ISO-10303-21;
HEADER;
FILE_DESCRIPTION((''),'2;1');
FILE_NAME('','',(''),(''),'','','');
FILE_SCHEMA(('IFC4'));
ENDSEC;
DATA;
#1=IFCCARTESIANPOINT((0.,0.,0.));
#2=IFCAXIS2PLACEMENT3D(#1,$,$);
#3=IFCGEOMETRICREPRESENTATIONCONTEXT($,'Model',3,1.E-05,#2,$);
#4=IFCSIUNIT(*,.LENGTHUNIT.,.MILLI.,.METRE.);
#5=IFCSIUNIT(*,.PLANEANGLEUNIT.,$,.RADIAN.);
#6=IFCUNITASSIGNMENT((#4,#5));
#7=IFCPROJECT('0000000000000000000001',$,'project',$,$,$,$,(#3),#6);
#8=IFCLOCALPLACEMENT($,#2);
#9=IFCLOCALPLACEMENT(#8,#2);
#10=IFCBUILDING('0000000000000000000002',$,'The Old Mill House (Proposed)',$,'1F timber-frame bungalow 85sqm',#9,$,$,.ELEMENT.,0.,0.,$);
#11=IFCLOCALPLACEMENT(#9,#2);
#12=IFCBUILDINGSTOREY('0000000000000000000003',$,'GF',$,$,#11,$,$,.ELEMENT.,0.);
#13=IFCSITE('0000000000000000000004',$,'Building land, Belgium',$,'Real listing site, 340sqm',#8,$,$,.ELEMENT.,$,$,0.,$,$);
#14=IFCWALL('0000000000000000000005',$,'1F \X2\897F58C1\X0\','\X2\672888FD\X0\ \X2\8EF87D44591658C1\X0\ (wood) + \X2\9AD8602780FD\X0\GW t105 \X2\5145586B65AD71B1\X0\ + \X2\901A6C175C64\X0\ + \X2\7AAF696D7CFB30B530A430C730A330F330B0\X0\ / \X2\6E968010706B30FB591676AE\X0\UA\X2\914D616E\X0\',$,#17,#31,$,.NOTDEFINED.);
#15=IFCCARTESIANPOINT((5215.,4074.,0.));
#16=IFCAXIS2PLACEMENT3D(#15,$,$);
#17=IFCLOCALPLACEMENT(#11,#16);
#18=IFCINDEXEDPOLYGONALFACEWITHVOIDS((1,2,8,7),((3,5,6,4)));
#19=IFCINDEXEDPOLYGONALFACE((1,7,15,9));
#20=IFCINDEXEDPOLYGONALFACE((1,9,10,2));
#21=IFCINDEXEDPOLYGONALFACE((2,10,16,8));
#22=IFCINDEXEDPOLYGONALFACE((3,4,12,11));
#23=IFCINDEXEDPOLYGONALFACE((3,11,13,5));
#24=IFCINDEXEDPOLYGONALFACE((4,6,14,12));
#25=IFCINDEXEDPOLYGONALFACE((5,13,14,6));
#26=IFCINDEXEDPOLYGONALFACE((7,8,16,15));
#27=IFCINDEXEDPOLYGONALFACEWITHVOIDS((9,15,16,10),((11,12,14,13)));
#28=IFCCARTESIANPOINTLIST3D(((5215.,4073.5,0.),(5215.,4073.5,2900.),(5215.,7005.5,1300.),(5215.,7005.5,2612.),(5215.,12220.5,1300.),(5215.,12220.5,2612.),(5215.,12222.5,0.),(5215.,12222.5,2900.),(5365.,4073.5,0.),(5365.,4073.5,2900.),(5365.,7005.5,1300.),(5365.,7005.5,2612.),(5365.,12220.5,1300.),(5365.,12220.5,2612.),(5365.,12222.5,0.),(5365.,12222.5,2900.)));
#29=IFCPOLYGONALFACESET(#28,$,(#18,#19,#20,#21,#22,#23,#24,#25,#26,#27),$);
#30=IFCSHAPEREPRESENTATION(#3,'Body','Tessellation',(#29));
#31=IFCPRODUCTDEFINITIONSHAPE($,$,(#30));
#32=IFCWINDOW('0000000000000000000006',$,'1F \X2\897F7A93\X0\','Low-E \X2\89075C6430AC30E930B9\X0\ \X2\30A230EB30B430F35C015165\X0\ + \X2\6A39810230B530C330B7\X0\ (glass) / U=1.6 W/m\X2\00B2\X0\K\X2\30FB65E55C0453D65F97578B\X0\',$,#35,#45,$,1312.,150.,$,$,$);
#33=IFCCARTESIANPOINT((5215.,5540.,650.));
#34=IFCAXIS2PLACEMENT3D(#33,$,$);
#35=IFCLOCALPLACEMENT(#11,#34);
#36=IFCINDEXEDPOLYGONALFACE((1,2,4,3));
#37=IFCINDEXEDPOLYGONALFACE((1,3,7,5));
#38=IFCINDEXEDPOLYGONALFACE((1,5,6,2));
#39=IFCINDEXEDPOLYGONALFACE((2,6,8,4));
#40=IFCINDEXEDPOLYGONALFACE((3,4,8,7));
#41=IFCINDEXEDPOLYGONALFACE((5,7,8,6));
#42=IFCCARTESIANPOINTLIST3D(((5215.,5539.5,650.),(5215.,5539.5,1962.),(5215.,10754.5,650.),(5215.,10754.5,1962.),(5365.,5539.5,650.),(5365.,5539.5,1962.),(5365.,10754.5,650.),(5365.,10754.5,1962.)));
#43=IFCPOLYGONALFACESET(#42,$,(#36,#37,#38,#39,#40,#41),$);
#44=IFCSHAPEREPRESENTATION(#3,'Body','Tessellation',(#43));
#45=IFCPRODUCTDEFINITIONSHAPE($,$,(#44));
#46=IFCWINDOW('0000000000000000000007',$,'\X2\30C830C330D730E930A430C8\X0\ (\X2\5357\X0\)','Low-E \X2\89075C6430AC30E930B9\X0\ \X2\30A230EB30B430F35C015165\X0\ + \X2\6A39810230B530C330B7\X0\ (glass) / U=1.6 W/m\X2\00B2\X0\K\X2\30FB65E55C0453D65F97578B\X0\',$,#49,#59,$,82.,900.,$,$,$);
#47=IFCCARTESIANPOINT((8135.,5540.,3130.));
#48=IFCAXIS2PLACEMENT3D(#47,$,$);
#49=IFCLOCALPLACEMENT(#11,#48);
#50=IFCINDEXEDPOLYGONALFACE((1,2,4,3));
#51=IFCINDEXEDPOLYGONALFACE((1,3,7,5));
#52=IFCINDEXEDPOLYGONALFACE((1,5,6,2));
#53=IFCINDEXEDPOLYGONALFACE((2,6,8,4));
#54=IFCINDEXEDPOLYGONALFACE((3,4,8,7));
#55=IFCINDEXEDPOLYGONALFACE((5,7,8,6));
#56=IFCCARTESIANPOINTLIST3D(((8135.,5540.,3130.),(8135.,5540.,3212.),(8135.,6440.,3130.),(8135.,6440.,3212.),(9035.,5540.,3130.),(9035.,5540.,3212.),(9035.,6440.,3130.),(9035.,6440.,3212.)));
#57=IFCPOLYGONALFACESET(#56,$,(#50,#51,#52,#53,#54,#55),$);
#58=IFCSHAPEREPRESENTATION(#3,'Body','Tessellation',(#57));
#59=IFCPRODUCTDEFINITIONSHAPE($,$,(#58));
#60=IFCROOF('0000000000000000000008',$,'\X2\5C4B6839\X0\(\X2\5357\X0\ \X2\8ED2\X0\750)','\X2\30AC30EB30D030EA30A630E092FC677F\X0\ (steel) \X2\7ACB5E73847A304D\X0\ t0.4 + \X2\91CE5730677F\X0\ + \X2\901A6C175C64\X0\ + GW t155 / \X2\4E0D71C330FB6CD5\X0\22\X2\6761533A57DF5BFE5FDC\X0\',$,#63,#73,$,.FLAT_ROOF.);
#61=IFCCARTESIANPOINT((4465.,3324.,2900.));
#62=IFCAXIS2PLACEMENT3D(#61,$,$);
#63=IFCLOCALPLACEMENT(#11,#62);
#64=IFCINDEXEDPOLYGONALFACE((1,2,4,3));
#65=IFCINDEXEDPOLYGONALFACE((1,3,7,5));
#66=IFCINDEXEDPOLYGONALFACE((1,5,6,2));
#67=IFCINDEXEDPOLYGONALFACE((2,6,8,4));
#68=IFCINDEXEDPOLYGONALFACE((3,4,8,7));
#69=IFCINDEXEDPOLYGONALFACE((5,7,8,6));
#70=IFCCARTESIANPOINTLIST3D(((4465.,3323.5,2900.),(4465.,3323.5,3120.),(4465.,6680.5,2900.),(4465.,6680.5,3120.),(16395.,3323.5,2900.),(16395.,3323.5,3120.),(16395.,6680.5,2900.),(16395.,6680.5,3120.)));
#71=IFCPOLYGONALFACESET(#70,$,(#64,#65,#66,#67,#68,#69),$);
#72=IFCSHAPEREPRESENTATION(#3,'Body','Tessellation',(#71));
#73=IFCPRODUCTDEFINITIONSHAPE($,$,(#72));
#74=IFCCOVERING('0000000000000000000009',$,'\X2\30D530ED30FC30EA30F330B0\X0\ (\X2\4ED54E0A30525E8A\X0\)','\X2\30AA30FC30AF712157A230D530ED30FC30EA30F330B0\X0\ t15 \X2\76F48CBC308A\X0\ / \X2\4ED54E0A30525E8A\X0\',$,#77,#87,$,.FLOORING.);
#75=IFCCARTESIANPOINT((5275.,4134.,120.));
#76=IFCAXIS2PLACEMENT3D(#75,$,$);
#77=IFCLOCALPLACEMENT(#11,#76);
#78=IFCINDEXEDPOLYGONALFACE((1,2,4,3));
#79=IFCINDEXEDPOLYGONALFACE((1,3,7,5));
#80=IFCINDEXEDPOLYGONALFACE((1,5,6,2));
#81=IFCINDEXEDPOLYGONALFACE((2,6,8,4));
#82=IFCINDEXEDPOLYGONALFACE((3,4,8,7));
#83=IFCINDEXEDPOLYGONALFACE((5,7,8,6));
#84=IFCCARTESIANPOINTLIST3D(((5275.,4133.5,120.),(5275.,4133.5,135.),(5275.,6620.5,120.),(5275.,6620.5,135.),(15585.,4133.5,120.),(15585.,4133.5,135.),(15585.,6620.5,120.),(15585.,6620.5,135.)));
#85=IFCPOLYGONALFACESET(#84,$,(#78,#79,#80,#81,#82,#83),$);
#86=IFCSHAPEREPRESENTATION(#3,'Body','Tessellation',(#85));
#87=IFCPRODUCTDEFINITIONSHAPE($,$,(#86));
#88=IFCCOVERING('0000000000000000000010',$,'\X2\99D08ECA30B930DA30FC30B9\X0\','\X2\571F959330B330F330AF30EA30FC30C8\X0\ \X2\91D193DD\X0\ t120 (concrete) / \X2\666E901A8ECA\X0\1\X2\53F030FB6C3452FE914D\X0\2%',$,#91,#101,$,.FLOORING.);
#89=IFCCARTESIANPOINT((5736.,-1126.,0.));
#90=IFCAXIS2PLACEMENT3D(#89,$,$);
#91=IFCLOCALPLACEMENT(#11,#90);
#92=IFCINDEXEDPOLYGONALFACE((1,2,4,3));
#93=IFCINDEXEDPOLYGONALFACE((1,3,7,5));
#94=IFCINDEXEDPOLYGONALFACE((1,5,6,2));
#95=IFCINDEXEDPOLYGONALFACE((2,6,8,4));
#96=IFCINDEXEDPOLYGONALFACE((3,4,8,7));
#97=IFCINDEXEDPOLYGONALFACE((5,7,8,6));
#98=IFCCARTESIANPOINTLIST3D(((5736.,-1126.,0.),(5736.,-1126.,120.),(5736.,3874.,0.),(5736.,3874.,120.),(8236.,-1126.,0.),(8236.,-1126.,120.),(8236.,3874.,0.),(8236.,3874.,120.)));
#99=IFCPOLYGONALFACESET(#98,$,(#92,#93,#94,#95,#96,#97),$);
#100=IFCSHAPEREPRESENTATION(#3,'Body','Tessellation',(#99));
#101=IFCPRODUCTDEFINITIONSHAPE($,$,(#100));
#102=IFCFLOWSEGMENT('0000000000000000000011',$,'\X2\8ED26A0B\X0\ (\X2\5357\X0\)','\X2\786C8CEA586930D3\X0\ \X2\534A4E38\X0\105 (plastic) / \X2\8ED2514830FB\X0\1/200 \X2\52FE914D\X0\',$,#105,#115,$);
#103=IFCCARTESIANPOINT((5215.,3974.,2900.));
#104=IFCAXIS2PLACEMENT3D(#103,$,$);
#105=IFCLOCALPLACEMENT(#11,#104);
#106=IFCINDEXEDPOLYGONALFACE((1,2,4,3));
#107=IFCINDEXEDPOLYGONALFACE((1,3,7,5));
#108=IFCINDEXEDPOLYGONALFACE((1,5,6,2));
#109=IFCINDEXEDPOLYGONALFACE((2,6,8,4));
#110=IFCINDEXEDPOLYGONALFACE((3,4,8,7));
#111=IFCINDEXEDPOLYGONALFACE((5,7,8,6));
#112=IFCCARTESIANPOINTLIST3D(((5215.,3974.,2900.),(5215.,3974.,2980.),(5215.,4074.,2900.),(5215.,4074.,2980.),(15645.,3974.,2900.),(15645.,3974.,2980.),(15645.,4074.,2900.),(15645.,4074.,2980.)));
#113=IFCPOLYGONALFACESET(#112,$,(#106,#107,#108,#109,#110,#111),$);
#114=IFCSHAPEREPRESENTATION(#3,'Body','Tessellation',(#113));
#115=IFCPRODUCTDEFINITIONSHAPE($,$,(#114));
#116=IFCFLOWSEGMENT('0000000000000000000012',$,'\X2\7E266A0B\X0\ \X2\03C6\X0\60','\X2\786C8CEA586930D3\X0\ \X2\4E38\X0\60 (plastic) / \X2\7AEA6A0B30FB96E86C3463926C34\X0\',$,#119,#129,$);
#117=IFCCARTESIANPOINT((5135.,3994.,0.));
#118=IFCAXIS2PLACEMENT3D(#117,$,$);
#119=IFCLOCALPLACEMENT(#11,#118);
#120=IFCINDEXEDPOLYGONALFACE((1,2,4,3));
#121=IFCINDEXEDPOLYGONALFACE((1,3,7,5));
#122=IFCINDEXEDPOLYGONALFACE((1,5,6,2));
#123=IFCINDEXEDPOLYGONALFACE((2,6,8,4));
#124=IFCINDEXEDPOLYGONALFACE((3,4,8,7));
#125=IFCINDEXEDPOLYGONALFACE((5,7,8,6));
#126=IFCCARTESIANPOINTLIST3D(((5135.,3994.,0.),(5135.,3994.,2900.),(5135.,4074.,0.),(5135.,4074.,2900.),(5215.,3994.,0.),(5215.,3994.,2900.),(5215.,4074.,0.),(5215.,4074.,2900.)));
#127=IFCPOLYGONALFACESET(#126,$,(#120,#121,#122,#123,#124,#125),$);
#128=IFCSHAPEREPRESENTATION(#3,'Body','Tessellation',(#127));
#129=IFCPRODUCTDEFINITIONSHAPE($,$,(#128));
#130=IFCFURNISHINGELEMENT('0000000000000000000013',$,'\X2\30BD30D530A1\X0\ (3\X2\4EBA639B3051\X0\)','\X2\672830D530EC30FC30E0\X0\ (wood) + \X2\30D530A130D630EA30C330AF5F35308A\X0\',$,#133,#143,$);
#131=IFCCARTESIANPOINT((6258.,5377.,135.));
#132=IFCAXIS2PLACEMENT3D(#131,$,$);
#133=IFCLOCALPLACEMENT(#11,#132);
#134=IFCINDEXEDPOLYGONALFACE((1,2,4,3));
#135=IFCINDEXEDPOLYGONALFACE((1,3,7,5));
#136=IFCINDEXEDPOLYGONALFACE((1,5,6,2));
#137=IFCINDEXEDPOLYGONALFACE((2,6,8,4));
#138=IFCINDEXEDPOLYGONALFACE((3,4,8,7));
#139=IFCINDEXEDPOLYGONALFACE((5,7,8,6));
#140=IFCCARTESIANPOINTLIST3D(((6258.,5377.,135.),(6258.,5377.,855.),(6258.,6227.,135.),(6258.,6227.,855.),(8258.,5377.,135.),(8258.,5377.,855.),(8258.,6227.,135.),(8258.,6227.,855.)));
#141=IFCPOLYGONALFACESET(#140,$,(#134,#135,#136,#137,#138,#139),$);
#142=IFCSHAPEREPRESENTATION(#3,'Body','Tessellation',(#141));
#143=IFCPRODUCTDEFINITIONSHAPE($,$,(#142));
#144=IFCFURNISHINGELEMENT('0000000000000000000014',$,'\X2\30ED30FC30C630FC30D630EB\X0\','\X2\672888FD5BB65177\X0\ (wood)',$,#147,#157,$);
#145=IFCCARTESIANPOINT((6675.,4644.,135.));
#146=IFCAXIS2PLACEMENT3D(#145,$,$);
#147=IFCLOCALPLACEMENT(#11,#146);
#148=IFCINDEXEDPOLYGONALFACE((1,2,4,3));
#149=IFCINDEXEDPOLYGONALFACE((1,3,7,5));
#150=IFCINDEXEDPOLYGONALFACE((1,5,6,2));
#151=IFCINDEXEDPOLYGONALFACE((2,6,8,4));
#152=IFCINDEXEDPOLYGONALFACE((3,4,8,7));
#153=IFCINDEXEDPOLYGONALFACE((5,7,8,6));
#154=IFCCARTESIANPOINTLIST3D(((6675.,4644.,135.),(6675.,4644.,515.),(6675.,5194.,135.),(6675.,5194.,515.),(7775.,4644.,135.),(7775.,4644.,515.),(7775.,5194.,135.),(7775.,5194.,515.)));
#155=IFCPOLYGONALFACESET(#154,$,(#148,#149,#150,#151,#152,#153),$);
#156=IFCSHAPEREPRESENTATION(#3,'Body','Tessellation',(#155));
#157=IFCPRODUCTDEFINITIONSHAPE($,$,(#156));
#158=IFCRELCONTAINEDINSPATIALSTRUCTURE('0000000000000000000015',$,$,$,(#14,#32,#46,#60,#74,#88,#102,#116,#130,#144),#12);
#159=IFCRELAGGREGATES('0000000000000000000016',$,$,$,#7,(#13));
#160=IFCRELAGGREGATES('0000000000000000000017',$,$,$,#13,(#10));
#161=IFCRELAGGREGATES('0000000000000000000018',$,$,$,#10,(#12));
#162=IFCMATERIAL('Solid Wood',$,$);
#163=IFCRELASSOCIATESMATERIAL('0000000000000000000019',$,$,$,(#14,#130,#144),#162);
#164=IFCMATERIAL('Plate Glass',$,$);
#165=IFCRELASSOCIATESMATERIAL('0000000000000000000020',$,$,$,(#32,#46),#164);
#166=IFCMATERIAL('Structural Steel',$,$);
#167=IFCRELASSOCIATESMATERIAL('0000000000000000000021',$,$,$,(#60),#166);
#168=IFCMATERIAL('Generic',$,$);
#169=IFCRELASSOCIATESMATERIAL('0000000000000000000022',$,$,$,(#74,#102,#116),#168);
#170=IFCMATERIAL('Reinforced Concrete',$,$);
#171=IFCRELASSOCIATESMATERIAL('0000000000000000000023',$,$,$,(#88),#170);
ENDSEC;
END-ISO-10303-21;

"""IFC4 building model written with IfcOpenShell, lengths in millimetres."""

from ifc_helpers import new_model, si_unit, frame, frame_2d, origin, place, context, project, spatial, rectangle, extrude, material, element, fill, save


model = new_model("IFC4")

# Units and contexts
model_context = context("Model", 3, precision=1e-05, world=origin())
ifc_project = project(units=[si_unit("LENGTHUNIT", "METRE", prefix="MILLI"), si_unit("PLANEANGLEUNIT", "RADIAN")], contexts=[model_context])

# Site, building, storey
site_placement = place(None, origin())
site = spatial("IfcSite", under=ifc_project, at=site_placement, Name="Building land, Belgium", ObjectType="Real listing site, 340sqm", CompositionType="ELEMENT", RefElevation=0.0)
building_placement = place(site_placement, origin())
building = spatial("IfcBuilding", under=site, at=building_placement, Name="The Old Mill House (Proposed)", ObjectType="1F timber-frame bungalow 85sqm", CompositionType="ELEMENT", ElevationOfRefHeight=0.0, ElevationOfTerrain=0.0)
storey_placement = place(building_placement, origin())
storey = spatial("IfcBuildingStorey", under=building, at=storey_placement, Name="GF", CompositionType="ELEMENT", Elevation=0.0)

# Shared definitions
ifc_material_1 = material(Name="Solid Wood")

# Shared definitions
ifc_material_2 = material(Name="Reinforced Concrete")

# Shared definitions
ifc_material_3 = material(Name="Plate Glass")

# Wall, opening, window
wall_1_placement = place(storey_placement, frame((5215.0, 4074.0, 0.0)))
wall_1 = element("IfcWall", 1, at=wall_1_placement, inside=storey, material=ifc_material_1, Name="1F 西壁", Description="木製 軸組外壁 (wood) + 高性能GW t105 充填断熱 + 通気層 + 窯業系サイディング / 準耐火・外皮UA配慮", PredefinedType="NOTDEFINED", context=model_context, shape_type="SweptSolid", body=[
    extrude(rectangle(XDim=150.0, YDim=8149.0, at=frame_2d((75.0, 4074.0))), frame((5215.0, 4074.0, 0.0)), (0.0, 0.0, 1.0), 2900.0),
])
opening_1_placement = place(storey_placement, frame((5215.0, 5540.0, 650.0)))
opening_1 = element("IfcOpeningElement", 2, at=opening_1_placement, cuts=wall_1, PredefinedType="NOTDEFINED", context=model_context, shape_type="SweptSolid", body=[
    extrude(rectangle(XDim=150.0, YDim=5215.0, at=frame_2d((75.0, 2607.0))), frame((5215.0, 5540.0, 650.0)), (0.0, 0.0, 1.0), 1312.0),
])
window_1_placement = place(storey_placement, frame((5215.0, 5540.0, 650.0)))
window_1 = element("IfcWindow", 3, at=window_1_placement, inside=storey, material=ifc_material_3, Name="1F 西窓", Description="Low-E 複層ガラス アルゴン封入 + 樹脂サッシ (glass) / U=1.6 W/m²K・日射取得型", OverallHeight=1312.0, OverallWidth=150.0, context=model_context, shape_type="SweptSolid", body=[
    extrude(rectangle(XDim=150.0, YDim=5215.0, at=frame_2d((75.0, 2607.0))), frame((5215.0, 5540.0, 650.0)), (0.0, 0.0, 1.0), 1312.0),
])
fill(opening_1, window_1)

# Window
window_2_placement = place(storey_placement, frame((8135.0, 5540.0, 3130.0)))
element("IfcWindow", 4, at=window_2_placement, inside=storey, material=ifc_material_3, Name="トップライト (南)", Description="Low-E 複層ガラス アルゴン封入 + 樹脂サッシ (glass) / U=1.6 W/m²K・日射取得型", OverallHeight=82.0, OverallWidth=900.0, context=model_context, shape_type="SweptSolid", body=[
    extrude(rectangle(XDim=900.0, YDim=900.0, at=frame_2d((450.0, 450.0))), frame((8135.0, 5540.0, 3130.0)), (0.0, 0.0, 1.0), 82.0),
])

# Roof
ifc_material_4 = material(Name="Structural Steel")
roof_1_placement = place(storey_placement, frame((4465.0, 3324.0, 2900.0)))
element("IfcRoof", 5, at=roof_1_placement, inside=storey, material=ifc_material_4, Name="屋根(南 軒750)", Description="ガルバリウム鋼板 (steel) 立平葺き t0.4 + 野地板 + 通気層 + GW t155 / 不燃・法22条区域対応", PredefinedType="FLAT_ROOF", context=model_context, shape_type="SweptSolid", body=[
    extrude(rectangle(XDim=11930.0, YDim=3357.0, at=frame_2d((5965.0, 1678.0))), frame((4465.0, 3324.0, 2900.0)), (0.0, 0.0, 1.0), 220.0),
])

# Coverings
ifc_material_5 = material(Name="Generic")
covering_1_placement = place(storey_placement, frame((5275.0, 4134.0, 120.0)))
element("IfcCovering", 6, at=covering_1_placement, inside=storey, material=ifc_material_5, Name="フローリング (仕上げ床)", Description="オーク無垢フローリング t15 直貼り / 仕上げ床", PredefinedType="FLOORING", context=model_context, shape_type="SweptSolid", body=[
    extrude(rectangle(XDim=10310.0, YDim=2487.0, at=frame_2d((5155.0, 1243.0))), frame((5275.0, 4134.0, 120.0)), (0.0, 0.0, 1.0), 15.0),
])
covering_2_placement = place(storey_placement, frame((5736.0, -1126.0, 0.0)))
element("IfcCovering", 7, at=covering_2_placement, inside=storey, material=ifc_material_2, Name="駐車スペース", Description="土間コンクリート 金鏝 t120 (concrete) / 普通車1台・水勾配2%", PredefinedType="FLOORING", context=model_context, shape_type="SweptSolid", body=[
    extrude(rectangle(XDim=2500.0, YDim=5000.0, at=frame_2d((1250.0, 2500.0))), frame((5736.0, -1126.0, 0.0)), (0.0, 0.0, 1.0), 120.0),
])

# Flow segments
flow_segment_1_placement = place(storey_placement, frame((5215.0, 3974.0, 2900.0)))
element("IfcFlowSegment", 8, at=flow_segment_1_placement, inside=storey, material=ifc_material_5, Name="軒樋 (南)", Description="硬質塩ビ 半丸105 (plastic) / 軒先・1/200 勾配", context=model_context, shape_type="SweptSolid", body=[
    extrude(rectangle(XDim=10430.0, YDim=100.0, at=frame_2d((5215.0, 50.0))), frame((5215.0, 3974.0, 2900.0)), (0.0, 0.0, 1.0), 80.0),
])
flow_segment_2_placement = place(storey_placement, frame((5135.0, 3994.0, 0.0)))
element("IfcFlowSegment", 9, at=flow_segment_2_placement, inside=storey, material=ifc_material_5, Name="縦樋 φ60", Description="硬質塩ビ 丸60 (plastic) / 竪樋・雨水排水", context=model_context, shape_type="SweptSolid", body=[
    extrude(rectangle(XDim=80.0, YDim=80.0, at=frame_2d((40.0, 40.0))), frame((5135.0, 3994.0, 0.0)), (0.0, 0.0, 1.0), 2900.0),
])

# Furnishing elements
furnishing_1_placement = place(storey_placement, frame((6258.0, 5377.0, 135.0)))
element("IfcFurnishingElement", 10, at=furnishing_1_placement, inside=storey, material=ifc_material_1, Name="ソファ (3人掛け)", Description="木フレーム (wood) + ファブリック張り", context=model_context, shape_type="SweptSolid", body=[
    extrude(rectangle(XDim=2000.0, YDim=850.0, at=frame_2d((1000.0, 425.0))), frame((6258.0, 5377.0, 135.0)), (0.0, 0.0, 1.0), 720.0),
])
furnishing_2_placement = place(storey_placement, frame((6675.0, 4644.0, 135.0)))
element("IfcFurnishingElement", 11, at=furnishing_2_placement, inside=storey, material=ifc_material_1, Name="ローテーブル", Description="木製家具 (wood)", context=model_context, shape_type="SweptSolid", body=[
    extrude(rectangle(XDim=1100.0, YDim=550.0, at=frame_2d((550.0, 275.0))), frame((6675.0, 4644.0, 135.0)), (0.0, 0.0, 1.0), 380.0),
])

save(model, "model.ifc")
